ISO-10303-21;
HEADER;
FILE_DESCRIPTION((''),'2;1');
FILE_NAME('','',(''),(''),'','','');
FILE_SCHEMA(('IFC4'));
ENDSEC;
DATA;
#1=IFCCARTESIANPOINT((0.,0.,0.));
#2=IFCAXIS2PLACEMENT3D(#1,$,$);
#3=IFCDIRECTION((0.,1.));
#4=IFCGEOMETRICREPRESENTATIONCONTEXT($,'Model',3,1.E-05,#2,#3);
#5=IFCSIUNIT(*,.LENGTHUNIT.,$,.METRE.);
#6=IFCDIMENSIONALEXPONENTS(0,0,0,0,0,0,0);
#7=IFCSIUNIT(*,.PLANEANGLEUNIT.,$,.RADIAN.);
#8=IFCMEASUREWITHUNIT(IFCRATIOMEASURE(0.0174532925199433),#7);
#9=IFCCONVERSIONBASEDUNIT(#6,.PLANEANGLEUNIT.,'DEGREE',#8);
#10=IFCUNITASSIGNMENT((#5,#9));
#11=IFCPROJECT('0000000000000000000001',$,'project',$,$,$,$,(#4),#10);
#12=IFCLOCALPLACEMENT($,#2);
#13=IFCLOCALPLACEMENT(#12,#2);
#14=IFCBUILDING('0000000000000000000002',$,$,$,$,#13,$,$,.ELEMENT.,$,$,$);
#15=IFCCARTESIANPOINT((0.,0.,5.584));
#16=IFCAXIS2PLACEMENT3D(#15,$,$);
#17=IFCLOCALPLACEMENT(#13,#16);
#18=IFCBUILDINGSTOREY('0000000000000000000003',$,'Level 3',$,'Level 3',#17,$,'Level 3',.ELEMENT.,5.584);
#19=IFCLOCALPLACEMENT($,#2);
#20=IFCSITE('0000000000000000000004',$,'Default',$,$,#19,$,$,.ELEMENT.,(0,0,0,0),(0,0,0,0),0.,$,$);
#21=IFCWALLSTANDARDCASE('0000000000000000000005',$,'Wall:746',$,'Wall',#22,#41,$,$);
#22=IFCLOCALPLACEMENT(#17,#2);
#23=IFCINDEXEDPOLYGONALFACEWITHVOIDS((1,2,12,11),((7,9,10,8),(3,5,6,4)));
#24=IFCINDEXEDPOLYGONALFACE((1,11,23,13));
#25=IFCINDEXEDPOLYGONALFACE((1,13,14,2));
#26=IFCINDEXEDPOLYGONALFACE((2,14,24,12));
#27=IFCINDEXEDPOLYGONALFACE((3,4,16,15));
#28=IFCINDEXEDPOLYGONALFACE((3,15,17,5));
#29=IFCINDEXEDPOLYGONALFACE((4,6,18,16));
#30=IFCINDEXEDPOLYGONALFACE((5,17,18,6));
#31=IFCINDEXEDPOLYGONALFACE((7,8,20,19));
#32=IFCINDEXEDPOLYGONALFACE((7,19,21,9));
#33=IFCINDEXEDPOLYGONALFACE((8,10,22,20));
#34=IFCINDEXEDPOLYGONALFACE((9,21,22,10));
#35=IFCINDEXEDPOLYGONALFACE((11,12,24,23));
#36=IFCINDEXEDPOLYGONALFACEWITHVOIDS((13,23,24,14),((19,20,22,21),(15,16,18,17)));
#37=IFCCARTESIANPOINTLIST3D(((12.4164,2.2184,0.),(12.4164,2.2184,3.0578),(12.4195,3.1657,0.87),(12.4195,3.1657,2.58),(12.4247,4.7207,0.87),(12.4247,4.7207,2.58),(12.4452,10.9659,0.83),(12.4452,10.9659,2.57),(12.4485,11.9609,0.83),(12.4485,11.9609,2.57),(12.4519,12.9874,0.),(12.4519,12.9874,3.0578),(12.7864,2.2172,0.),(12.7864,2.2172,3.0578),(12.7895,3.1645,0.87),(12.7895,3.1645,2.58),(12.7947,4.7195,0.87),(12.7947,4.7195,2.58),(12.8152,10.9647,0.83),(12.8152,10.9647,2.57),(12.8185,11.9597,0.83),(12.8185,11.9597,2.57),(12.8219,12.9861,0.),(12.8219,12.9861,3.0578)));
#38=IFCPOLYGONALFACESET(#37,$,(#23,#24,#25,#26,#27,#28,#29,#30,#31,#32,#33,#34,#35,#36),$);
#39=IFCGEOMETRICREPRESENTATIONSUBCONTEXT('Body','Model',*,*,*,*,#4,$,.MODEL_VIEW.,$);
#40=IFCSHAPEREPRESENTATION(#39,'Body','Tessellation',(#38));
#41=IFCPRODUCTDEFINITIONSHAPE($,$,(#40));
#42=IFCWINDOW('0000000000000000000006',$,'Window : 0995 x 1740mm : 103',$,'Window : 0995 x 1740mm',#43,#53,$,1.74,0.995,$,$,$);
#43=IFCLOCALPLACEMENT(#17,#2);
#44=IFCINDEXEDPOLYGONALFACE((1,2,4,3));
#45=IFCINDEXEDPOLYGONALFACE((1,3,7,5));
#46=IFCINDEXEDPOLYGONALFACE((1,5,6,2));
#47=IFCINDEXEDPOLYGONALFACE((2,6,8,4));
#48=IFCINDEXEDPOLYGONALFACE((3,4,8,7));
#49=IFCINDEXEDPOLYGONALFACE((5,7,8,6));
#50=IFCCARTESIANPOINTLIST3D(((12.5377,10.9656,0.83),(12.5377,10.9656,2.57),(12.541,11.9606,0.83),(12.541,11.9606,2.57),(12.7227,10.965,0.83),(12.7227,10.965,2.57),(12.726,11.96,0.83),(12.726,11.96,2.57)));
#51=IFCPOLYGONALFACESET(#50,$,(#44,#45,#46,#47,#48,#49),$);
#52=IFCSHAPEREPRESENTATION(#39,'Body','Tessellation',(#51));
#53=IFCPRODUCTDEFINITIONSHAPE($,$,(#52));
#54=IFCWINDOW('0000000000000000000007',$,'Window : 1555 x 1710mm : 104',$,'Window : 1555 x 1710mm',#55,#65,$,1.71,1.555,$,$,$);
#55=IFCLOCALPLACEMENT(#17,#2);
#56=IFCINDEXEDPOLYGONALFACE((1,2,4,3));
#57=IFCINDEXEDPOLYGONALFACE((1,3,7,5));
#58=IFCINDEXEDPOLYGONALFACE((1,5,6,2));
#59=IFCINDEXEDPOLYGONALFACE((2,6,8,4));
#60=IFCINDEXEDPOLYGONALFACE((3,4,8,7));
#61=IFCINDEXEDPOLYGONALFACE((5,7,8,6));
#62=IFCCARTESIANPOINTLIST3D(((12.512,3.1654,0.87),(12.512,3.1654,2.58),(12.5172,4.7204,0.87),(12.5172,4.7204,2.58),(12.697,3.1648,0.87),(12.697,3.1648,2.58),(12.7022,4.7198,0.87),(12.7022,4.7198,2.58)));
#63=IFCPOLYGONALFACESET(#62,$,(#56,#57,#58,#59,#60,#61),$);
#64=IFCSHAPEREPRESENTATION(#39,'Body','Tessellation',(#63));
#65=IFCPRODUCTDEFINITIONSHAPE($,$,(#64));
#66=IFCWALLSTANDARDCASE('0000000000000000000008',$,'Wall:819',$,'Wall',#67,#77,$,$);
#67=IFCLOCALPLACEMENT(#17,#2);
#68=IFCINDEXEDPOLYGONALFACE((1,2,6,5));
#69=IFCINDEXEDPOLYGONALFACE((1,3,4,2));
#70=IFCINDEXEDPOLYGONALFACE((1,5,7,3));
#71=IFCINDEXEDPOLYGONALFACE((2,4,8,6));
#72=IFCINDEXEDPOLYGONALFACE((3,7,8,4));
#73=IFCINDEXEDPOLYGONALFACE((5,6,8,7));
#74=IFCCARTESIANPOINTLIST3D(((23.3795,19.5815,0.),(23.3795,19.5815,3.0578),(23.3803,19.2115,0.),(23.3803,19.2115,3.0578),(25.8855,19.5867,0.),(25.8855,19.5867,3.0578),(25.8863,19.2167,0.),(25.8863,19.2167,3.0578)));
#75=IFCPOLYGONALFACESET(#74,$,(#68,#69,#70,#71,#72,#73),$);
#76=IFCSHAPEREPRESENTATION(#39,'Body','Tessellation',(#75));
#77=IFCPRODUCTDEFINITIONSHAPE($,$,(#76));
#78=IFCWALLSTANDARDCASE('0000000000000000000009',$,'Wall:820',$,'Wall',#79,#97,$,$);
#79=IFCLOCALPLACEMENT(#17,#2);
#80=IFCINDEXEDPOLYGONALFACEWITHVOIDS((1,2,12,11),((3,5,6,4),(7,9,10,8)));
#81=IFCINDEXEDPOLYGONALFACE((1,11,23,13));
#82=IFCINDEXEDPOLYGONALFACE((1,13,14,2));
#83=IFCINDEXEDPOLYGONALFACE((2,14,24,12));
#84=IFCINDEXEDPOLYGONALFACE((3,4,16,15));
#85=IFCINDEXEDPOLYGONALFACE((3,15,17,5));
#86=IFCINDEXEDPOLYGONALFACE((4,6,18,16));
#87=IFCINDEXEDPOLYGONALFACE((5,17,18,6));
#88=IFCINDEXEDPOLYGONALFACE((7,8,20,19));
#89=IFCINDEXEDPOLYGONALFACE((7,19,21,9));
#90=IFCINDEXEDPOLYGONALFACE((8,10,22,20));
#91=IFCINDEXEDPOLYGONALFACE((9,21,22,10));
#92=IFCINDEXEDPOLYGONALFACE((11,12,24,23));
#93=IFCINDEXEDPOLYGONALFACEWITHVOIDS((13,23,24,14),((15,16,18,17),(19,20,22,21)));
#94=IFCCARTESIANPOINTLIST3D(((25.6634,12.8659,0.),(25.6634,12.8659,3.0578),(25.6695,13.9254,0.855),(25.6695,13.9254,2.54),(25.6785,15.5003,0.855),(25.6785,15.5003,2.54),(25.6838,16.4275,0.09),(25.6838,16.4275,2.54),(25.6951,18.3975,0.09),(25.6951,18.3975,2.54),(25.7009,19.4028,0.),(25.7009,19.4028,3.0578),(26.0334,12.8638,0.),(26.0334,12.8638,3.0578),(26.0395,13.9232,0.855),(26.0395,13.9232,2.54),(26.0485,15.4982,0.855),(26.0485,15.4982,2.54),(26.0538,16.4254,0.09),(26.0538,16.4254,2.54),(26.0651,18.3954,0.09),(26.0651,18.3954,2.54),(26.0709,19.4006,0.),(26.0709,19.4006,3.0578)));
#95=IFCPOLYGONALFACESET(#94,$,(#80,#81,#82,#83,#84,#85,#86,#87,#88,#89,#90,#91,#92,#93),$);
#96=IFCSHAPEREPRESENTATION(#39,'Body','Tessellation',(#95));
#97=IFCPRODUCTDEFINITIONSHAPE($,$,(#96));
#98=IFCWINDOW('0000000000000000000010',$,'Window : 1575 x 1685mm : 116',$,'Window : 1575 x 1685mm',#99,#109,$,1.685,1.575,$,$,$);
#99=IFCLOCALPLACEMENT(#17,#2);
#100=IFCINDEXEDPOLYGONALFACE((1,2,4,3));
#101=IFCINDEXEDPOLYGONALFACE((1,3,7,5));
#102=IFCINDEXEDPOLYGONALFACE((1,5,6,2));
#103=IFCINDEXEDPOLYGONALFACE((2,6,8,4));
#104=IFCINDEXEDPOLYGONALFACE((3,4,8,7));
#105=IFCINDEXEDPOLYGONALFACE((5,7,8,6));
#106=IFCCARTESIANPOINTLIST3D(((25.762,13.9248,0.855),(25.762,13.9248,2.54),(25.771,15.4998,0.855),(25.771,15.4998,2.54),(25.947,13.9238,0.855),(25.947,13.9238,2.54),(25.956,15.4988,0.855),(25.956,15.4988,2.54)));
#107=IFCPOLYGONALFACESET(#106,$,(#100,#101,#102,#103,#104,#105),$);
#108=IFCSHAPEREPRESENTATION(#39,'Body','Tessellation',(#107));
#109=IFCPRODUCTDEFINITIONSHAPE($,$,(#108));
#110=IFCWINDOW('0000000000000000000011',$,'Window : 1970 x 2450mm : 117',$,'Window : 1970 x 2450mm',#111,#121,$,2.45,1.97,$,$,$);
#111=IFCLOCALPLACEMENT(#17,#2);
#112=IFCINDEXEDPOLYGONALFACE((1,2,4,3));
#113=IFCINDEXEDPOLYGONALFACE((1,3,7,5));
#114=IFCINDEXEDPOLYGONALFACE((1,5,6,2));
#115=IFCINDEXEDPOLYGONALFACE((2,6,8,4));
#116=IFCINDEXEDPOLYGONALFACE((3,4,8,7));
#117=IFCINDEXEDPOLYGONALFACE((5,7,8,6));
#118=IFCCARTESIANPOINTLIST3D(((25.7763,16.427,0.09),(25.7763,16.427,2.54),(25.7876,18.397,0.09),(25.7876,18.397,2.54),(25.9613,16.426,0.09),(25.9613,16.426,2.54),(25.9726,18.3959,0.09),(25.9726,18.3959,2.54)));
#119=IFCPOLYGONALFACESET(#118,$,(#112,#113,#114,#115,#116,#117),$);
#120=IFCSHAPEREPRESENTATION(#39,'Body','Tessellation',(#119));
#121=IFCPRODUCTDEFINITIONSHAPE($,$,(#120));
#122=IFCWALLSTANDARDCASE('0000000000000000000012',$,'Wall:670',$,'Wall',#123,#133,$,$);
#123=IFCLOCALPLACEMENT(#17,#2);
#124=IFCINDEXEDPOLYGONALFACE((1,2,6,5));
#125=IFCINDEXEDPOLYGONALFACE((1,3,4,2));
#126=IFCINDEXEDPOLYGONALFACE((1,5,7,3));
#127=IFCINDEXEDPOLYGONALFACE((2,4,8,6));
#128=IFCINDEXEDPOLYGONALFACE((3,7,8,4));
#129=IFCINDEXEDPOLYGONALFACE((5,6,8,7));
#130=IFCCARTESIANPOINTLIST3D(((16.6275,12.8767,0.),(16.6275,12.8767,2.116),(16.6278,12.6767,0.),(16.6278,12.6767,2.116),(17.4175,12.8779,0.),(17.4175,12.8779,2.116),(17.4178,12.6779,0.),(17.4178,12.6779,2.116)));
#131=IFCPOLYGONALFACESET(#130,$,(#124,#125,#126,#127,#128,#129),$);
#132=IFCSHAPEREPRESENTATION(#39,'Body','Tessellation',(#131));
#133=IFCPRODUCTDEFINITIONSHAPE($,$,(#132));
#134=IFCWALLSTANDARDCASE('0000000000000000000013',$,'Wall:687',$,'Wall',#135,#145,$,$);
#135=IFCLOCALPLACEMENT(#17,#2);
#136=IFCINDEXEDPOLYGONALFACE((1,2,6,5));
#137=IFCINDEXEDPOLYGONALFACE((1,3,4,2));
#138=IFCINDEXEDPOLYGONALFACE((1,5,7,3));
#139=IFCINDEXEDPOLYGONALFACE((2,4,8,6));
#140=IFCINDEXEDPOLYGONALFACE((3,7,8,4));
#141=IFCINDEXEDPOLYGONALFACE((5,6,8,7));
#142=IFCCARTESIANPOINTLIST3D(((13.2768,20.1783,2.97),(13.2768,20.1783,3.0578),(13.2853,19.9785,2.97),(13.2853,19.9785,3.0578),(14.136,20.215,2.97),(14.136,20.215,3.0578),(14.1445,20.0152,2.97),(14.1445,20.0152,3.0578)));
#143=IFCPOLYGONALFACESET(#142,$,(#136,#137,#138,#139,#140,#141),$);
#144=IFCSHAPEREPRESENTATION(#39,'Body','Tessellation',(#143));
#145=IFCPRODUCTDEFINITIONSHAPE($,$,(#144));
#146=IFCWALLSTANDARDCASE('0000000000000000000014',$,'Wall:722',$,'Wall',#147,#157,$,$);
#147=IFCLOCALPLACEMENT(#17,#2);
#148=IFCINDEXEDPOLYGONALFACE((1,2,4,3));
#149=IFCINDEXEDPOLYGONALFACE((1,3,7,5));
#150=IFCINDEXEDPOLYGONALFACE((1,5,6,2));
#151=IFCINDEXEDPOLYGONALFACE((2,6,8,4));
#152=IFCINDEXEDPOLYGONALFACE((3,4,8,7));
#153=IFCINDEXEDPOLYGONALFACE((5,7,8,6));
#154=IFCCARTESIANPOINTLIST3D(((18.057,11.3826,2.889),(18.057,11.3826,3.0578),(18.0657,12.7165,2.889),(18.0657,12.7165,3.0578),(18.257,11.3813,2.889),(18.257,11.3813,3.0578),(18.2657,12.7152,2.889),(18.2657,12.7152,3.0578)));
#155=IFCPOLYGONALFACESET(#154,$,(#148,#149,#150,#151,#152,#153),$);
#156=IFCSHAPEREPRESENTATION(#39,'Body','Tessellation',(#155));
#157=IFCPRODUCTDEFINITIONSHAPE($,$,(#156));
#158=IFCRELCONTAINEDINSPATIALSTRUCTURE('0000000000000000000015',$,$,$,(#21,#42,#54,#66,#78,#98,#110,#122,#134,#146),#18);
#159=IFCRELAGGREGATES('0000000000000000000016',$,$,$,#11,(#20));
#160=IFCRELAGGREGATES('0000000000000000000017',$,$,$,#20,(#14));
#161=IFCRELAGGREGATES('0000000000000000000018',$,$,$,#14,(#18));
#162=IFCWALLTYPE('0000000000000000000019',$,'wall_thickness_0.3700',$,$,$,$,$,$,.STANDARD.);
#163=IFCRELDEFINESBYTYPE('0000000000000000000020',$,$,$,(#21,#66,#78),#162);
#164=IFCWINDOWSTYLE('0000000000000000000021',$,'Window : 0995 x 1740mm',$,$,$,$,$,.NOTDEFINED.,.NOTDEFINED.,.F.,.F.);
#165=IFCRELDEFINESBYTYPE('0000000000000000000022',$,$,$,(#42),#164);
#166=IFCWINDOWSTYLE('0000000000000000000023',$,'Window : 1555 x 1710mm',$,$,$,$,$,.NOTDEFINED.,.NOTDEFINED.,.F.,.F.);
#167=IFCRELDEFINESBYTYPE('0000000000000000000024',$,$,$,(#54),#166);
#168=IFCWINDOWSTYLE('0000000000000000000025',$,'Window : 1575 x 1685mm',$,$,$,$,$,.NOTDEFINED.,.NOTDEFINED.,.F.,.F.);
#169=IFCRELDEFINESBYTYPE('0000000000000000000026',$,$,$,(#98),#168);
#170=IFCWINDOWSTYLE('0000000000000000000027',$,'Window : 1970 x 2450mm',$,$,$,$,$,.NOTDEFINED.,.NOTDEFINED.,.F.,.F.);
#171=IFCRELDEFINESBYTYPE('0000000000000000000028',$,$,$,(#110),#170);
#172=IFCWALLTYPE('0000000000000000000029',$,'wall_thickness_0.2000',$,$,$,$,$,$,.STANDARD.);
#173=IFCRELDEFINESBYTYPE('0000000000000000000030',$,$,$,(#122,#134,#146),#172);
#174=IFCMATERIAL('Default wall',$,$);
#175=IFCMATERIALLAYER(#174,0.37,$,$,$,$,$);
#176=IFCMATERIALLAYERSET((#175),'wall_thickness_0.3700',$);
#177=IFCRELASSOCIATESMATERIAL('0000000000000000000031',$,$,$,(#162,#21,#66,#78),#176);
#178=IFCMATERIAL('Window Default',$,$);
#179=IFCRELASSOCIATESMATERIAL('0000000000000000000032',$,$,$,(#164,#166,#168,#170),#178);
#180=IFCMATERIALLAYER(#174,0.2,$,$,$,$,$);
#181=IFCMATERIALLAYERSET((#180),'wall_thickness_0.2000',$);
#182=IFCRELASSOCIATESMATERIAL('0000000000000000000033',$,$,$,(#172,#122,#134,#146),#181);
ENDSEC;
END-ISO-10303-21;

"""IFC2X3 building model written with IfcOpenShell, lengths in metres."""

from ifc_helpers import new_model, entity, si_unit, converted_unit, direction, frame, frame_2d, origin, origin_2d_with_axis, place, context, subcontext, project, spatial, polyline, rectangle, outline, extrude, source, transform, mapped, material, layer, layer_set, layer_usage, type_object, type_shapes, element, fill, save


model = new_model("IFC2X3")

# Units and contexts
model_context = context("Model", 3, precision=1e-05, world=origin(), true_north=direction((0.0, 1.0)))
body_context = subcontext(model_context, "Body", "Model", "MODEL_VIEW")
ifc_project = project(units=[si_unit("LENGTHUNIT", "METRE"), converted_unit("PLANEANGLEUNIT", "DEGREE", entity("IfcRatioMeasure", 0.0174532925199433), si_unit("PLANEANGLEUNIT", "RADIAN"), dimensions=[0, 0, 0, 0, 0, 0, 0])], contexts=[model_context])

# Site, building, storey
site_placement = place(None, origin())
site = spatial("IfcSite", under=ifc_project, at=site_placement, Name="Default", CompositionType="ELEMENT", RefLatitude=(0, 0, 0, 0), RefLongitude=(0, 0, 0, 0), RefElevation=0.0)
placement_1 = place(None, origin())
building_placement = place(placement_1, origin())
building = spatial("IfcBuilding", under=site, at=building_placement, CompositionType="ELEMENT")
storey_placement = place(building_placement, frame((0.0, 0.0, 5.584)))
storey = spatial("IfcBuildingStorey", under=building, at=storey_placement, Name="Level 3", ObjectType="Level 3", LongName="Level 3", CompositionType="ELEMENT", Elevation=5.584)

# Wall, openings, windows
ifc_material_1 = material(Name="Default wall")
ifc_layer_1 = layer(ifc_material_1, 0.37)
ifc_layer_set_1 = layer_set([ifc_layer_1], Name="wall_thickness_0.3700")
ifc_layer_usage_1 = layer_usage(ifc_layer_set_1, "AXIS2", "POSITIVE", -0.185)
wall_type_1 = type_object("IfcWallType", Name="wall_thickness_0.3700", PredefinedType="STANDARD", material=ifc_layer_set_1)
wall_1_placement = place(storey_placement, frame((12.6369, 12.9867, 0.0), z_axis=(0.0, 0.0, 1.0), x_axis=(-0.003295, -0.999995, 0.0)))
wall_1 = element("IfcWallStandardCase", 1, at=wall_1_placement, inside=storey, type_object=wall_type_1, material=ifc_layer_usage_1, Name="Wall:746", ObjectType="Wall", context=body_context, shape_type="SweptSolid", body=[
    extrude(outline(polyline([(10.769, -0.185), (10.769, 0.185), (0.0, 0.185), (0.0, -0.185), (10.769, -0.185)])), origin(), (0.0, 0.0, 1.0), 3.0578),
])
opening_1_placement = place(wall_1_placement, frame((1.0264, -0.185, 0.83)))
opening_1 = element("IfcOpeningElement", 2, at=opening_1_placement, cuts=wall_1, ObjectType="Opening", context=body_context, shape_type="SweptSolid", body=[
    extrude(rectangle(XDim=0.995, YDim=1.74, at=frame_2d((0.87, 0.4975), x_axis=(0.0, 1.0))), frame((0.0, 0.0, 0.0), z_axis=(0.0, 1.0, 0.0), x_axis=(0.0, 0.0, 1.0)), (0.0, 0.0, 1.0), 0.37),
])
opening_2_placement = place(wall_1_placement, frame((8.2667, -0.185, 0.87)))
opening_2 = element("IfcOpeningElement", 3, at=opening_2_placement, cuts=wall_1, ObjectType="Opening", context=body_context, shape_type="SweptSolid", body=[
    extrude(rectangle(XDim=1.555, YDim=1.71, at=frame_2d((0.855, 0.7775), x_axis=(0.0, 1.0))), frame((0.0, 0.0, 0.0), z_axis=(0.0, 1.0, 0.0), x_axis=(0.0, 0.0, 1.0)), (0.0, 0.0, 1.0), 0.37),
])
ifc_material_2 = material(Name="Window Default")
window_style_1 = type_object("IfcWindowStyle", Name="Window : 0995 x 1740mm", ConstructionType="NOTDEFINED", OperationType="NOTDEFINED", ParameterTakesPrecedence=False, Sizeable=False, material=ifc_material_2)
shared_shape_1 = source(origin(), body_context, "Body", "SweptSolid", [
    extrude(rectangle(XDim=0.185, YDim=0.995, at=origin_2d_with_axis()), frame((0.4975, 0.185, 0.0), z_axis=(0.0, 0.0, 1.0), x_axis=(0.0, 1.0, 0.0)), (0.0, 0.0, 1.0), 1.74),
])
type_shapes(window_style_1, [shared_shape_1])
window_1_placement = place(opening_1_placement, origin())
window_1 = element("IfcWindow", 4, at=window_1_placement, inside=storey, type_object=window_style_1, Name="Window : 0995 x 1740mm : 103", ObjectType="Window : 0995 x 1740mm", OverallHeight=1.74, OverallWidth=0.995, context=body_context, shape_type="MappedRepresentation", body=[
    mapped(shared_shape_1, transform((0.0, 0.0, 0.0), scale=1.0)),
])
fill(opening_1, window_1)
window_style_2 = type_object("IfcWindowStyle", Name="Window : 1555 x 1710mm", ConstructionType="NOTDEFINED", OperationType="NOTDEFINED", ParameterTakesPrecedence=False, Sizeable=False, material=ifc_material_2)
shared_shape_2 = source(origin(), body_context, "Body", "SweptSolid", [
    extrude(rectangle(XDim=0.185, YDim=1.555, at=origin_2d_with_axis()), frame((0.7775, 0.185, 0.0), z_axis=(0.0, 0.0, 1.0), x_axis=(0.0, 1.0, 0.0)), (0.0, 0.0, 1.0), 1.71),
])
type_shapes(window_style_2, [shared_shape_2])
window_2_placement = place(opening_2_placement, origin())
window_2 = element("IfcWindow", 5, at=window_2_placement, inside=storey, type_object=window_style_2, Name="Window : 1555 x 1710mm : 104", ObjectType="Window : 1555 x 1710mm", OverallHeight=1.71, OverallWidth=1.555, context=body_context, shape_type="MappedRepresentation", body=[
    mapped(shared_shape_2, transform((0.0, 0.0, 0.0), scale=1.0)),
])
fill(opening_2, window_2)

# Wall
wall_2_placement = place(storey_placement, frame((23.3799, 19.3965, 0.0), z_axis=(0.0, 0.0, 1.0), x_axis=(0.999998, 0.00208, 0.0)))
element("IfcWallStandardCase", 6, at=wall_2_placement, inside=storey, type_object=wall_type_1, material=ifc_layer_usage_1, Name="Wall:819", ObjectType="Wall", context=body_context, shape_type="SweptSolid", body=[
    extrude(outline(polyline([(2.506, -0.185), (2.506, 0.185), (0.0, 0.185), (0.0, -0.185), (2.506, -0.185)])), origin(), (0.0, 0.0, 1.0), 3.0578),
])

# Wall, openings, windows
wall_3_placement = place(storey_placement, frame((25.8859, 19.4017, 0.0), z_axis=(0.0, 0.0, 1.0), x_axis=(-0.005738, -0.999984, 0.0)))
wall_3 = element("IfcWallStandardCase", 7, at=wall_3_placement, inside=storey, type_object=wall_type_1, material=ifc_layer_usage_1, Name="Wall:820", ObjectType="Wall", context=body_context, shape_type="SweptSolid", body=[
    extrude(outline(polyline([(6.537, -0.185), (6.537, 0.185), (0.0, 0.185), (0.0, -0.185), (6.537, -0.185)])), origin(), (0.0, 0.0, 1.0), 3.0578),
])
opening_3_placement = place(wall_3_placement, frame((3.9025, -0.185, 0.855)))
opening_3 = element("IfcOpeningElement", 8, at=opening_3_placement, cuts=wall_3, ObjectType="Opening", context=body_context, shape_type="SweptSolid", body=[
    extrude(rectangle(XDim=1.575, YDim=1.685, at=frame_2d((0.8425, 0.7875), x_axis=(0.0, 1.0))), frame((0.0, 0.0, 0.0), z_axis=(0.0, 1.0, 0.0), x_axis=(0.0, 0.0, 1.0)), (0.0, 0.0, 1.0), 0.37),
])
opening_4_placement = place(wall_3_placement, frame((1.0053, -0.185, 0.09)))
opening_4 = element("IfcOpeningElement", 9, at=opening_4_placement, cuts=wall_3, ObjectType="Opening", context=body_context, shape_type="SweptSolid", body=[
    extrude(rectangle(XDim=1.97, YDim=2.45, at=frame_2d((1.225, 0.985), x_axis=(0.0, 1.0))), frame((0.0, 0.0, 0.0), z_axis=(0.0, 1.0, 0.0), x_axis=(0.0, 0.0, 1.0)), (0.0, 0.0, 1.0), 0.37),
])
window_style_3 = type_object("IfcWindowStyle", Name="Window : 1575 x 1685mm", ConstructionType="NOTDEFINED", OperationType="NOTDEFINED", ParameterTakesPrecedence=False, Sizeable=False, material=ifc_material_2)
shared_shape_3 = source(origin(), body_context, "Body", "SweptSolid", [
    extrude(rectangle(XDim=0.185, YDim=1.575, at=origin_2d_with_axis()), frame((0.7875, 0.185, 0.0), z_axis=(0.0, 0.0, 1.0), x_axis=(0.0, 1.0, 0.0)), (0.0, 0.0, 1.0), 1.685),
])
type_shapes(window_style_3, [shared_shape_3])
window_3_placement = place(opening_3_placement, origin())
window_3 = element("IfcWindow", 10, at=window_3_placement, inside=storey, type_object=window_style_3, Name="Window : 1575 x 1685mm : 116", ObjectType="Window : 1575 x 1685mm", OverallHeight=1.685, OverallWidth=1.575, context=body_context, shape_type="MappedRepresentation", body=[
    mapped(shared_shape_3, transform((0.0, 0.0, 0.0), scale=1.0)),
])
fill(opening_3, window_3)
window_style_4 = type_object("IfcWindowStyle", Name="Window : 1970 x 2450mm", ConstructionType="NOTDEFINED", OperationType="NOTDEFINED", ParameterTakesPrecedence=False, Sizeable=False, material=ifc_material_2)
shared_shape_4 = source(origin(), body_context, "Body", "SweptSolid", [
    extrude(rectangle(XDim=0.185, YDim=1.97, at=origin_2d_with_axis()), frame((0.985, 0.185, 0.0), z_axis=(0.0, 0.0, 1.0), x_axis=(0.0, 1.0, 0.0)), (0.0, 0.0, 1.0), 2.45),
])
type_shapes(window_style_4, [shared_shape_4])
window_4_placement = place(opening_4_placement, origin())
window_4 = element("IfcWindow", 11, at=window_4_placement, inside=storey, type_object=window_style_4, Name="Window : 1970 x 2450mm : 117", ObjectType="Window : 1970 x 2450mm", OverallHeight=2.45, OverallWidth=1.97, context=body_context, shape_type="MappedRepresentation", body=[
    mapped(shared_shape_4, transform((0.0, 0.0, 0.0), scale=1.0)),
])
fill(opening_4, window_4)

# Walls
ifc_layer_2 = layer(ifc_material_1, 0.2)
ifc_layer_set_2 = layer_set([ifc_layer_2], Name="wall_thickness_0.2000")
ifc_layer_usage_2 = layer_usage(ifc_layer_set_2, "AXIS2", "POSITIVE", -0.1)
wall_type_2 = type_object("IfcWallType", Name="wall_thickness_0.2000", PredefinedType="STANDARD", material=ifc_layer_set_2)
wall_4_placement = place(storey_placement, frame((16.6277, 12.7767, 0.0), z_axis=(0.0, 0.0, 1.0), x_axis=(0.999999, 0.001472, 0.0)))
element("IfcWallStandardCase", 12, at=wall_4_placement, inside=storey, type_object=wall_type_2, material=ifc_layer_usage_2, Name="Wall:670", ObjectType="Wall", context=body_context, shape_type="SweptSolid", body=[
    extrude(outline(polyline([(0.79, -0.1), (0.79, 0.1), (0.0, 0.1), (0.0, -0.1), (0.79, -0.1)])), origin(), (0.0, 0.0, 1.0), 2.116),
])
placement_2 = place(building_placement, frame((0.0, 0.0, 8.554)))
wall_5_placement = place(placement_2, frame((13.2811, 20.0784, 0.0), z_axis=(0.0, 0.0, 1.0), x_axis=(0.999085, 0.042769, 0.0)))
element("IfcWallStandardCase", 13, at=wall_5_placement, inside=storey, type_object=wall_type_2, material=ifc_layer_usage_2, Name="Wall:687", ObjectType="Wall", context=body_context, shape_type="SweptSolid", body=[
    extrude(outline(polyline([(0.86, -0.1), (0.86, 0.1), (0.0, 0.1), (0.0, -0.1), (0.86, -0.1)])), origin(), (0.0, 0.0, 1.0), 0.0878),
])
placement_3 = place(building_placement, frame((0.0, 0.0, 8.473)))
wall_6_placement = place(placement_3, frame((18.1657, 12.7158, 0.0), z_axis=(0.0, 0.0, 1.0), x_axis=(-0.00653, -0.999979, 0.0)))
element("IfcWallStandardCase", 14, at=wall_6_placement, inside=storey, type_object=wall_type_2, material=ifc_layer_usage_2, Name="Wall:722", ObjectType="Wall", context=body_context, shape_type="SweptSolid", body=[
    extrude(outline(polyline([(1.3339, -0.1), (1.3339, 0.1), (0.0, 0.1), (0.0, -0.1), (1.3339, -0.1)])), origin(), (0.0, 0.0, 1.0), 0.1688),
])

save(model, "model.ifc")
